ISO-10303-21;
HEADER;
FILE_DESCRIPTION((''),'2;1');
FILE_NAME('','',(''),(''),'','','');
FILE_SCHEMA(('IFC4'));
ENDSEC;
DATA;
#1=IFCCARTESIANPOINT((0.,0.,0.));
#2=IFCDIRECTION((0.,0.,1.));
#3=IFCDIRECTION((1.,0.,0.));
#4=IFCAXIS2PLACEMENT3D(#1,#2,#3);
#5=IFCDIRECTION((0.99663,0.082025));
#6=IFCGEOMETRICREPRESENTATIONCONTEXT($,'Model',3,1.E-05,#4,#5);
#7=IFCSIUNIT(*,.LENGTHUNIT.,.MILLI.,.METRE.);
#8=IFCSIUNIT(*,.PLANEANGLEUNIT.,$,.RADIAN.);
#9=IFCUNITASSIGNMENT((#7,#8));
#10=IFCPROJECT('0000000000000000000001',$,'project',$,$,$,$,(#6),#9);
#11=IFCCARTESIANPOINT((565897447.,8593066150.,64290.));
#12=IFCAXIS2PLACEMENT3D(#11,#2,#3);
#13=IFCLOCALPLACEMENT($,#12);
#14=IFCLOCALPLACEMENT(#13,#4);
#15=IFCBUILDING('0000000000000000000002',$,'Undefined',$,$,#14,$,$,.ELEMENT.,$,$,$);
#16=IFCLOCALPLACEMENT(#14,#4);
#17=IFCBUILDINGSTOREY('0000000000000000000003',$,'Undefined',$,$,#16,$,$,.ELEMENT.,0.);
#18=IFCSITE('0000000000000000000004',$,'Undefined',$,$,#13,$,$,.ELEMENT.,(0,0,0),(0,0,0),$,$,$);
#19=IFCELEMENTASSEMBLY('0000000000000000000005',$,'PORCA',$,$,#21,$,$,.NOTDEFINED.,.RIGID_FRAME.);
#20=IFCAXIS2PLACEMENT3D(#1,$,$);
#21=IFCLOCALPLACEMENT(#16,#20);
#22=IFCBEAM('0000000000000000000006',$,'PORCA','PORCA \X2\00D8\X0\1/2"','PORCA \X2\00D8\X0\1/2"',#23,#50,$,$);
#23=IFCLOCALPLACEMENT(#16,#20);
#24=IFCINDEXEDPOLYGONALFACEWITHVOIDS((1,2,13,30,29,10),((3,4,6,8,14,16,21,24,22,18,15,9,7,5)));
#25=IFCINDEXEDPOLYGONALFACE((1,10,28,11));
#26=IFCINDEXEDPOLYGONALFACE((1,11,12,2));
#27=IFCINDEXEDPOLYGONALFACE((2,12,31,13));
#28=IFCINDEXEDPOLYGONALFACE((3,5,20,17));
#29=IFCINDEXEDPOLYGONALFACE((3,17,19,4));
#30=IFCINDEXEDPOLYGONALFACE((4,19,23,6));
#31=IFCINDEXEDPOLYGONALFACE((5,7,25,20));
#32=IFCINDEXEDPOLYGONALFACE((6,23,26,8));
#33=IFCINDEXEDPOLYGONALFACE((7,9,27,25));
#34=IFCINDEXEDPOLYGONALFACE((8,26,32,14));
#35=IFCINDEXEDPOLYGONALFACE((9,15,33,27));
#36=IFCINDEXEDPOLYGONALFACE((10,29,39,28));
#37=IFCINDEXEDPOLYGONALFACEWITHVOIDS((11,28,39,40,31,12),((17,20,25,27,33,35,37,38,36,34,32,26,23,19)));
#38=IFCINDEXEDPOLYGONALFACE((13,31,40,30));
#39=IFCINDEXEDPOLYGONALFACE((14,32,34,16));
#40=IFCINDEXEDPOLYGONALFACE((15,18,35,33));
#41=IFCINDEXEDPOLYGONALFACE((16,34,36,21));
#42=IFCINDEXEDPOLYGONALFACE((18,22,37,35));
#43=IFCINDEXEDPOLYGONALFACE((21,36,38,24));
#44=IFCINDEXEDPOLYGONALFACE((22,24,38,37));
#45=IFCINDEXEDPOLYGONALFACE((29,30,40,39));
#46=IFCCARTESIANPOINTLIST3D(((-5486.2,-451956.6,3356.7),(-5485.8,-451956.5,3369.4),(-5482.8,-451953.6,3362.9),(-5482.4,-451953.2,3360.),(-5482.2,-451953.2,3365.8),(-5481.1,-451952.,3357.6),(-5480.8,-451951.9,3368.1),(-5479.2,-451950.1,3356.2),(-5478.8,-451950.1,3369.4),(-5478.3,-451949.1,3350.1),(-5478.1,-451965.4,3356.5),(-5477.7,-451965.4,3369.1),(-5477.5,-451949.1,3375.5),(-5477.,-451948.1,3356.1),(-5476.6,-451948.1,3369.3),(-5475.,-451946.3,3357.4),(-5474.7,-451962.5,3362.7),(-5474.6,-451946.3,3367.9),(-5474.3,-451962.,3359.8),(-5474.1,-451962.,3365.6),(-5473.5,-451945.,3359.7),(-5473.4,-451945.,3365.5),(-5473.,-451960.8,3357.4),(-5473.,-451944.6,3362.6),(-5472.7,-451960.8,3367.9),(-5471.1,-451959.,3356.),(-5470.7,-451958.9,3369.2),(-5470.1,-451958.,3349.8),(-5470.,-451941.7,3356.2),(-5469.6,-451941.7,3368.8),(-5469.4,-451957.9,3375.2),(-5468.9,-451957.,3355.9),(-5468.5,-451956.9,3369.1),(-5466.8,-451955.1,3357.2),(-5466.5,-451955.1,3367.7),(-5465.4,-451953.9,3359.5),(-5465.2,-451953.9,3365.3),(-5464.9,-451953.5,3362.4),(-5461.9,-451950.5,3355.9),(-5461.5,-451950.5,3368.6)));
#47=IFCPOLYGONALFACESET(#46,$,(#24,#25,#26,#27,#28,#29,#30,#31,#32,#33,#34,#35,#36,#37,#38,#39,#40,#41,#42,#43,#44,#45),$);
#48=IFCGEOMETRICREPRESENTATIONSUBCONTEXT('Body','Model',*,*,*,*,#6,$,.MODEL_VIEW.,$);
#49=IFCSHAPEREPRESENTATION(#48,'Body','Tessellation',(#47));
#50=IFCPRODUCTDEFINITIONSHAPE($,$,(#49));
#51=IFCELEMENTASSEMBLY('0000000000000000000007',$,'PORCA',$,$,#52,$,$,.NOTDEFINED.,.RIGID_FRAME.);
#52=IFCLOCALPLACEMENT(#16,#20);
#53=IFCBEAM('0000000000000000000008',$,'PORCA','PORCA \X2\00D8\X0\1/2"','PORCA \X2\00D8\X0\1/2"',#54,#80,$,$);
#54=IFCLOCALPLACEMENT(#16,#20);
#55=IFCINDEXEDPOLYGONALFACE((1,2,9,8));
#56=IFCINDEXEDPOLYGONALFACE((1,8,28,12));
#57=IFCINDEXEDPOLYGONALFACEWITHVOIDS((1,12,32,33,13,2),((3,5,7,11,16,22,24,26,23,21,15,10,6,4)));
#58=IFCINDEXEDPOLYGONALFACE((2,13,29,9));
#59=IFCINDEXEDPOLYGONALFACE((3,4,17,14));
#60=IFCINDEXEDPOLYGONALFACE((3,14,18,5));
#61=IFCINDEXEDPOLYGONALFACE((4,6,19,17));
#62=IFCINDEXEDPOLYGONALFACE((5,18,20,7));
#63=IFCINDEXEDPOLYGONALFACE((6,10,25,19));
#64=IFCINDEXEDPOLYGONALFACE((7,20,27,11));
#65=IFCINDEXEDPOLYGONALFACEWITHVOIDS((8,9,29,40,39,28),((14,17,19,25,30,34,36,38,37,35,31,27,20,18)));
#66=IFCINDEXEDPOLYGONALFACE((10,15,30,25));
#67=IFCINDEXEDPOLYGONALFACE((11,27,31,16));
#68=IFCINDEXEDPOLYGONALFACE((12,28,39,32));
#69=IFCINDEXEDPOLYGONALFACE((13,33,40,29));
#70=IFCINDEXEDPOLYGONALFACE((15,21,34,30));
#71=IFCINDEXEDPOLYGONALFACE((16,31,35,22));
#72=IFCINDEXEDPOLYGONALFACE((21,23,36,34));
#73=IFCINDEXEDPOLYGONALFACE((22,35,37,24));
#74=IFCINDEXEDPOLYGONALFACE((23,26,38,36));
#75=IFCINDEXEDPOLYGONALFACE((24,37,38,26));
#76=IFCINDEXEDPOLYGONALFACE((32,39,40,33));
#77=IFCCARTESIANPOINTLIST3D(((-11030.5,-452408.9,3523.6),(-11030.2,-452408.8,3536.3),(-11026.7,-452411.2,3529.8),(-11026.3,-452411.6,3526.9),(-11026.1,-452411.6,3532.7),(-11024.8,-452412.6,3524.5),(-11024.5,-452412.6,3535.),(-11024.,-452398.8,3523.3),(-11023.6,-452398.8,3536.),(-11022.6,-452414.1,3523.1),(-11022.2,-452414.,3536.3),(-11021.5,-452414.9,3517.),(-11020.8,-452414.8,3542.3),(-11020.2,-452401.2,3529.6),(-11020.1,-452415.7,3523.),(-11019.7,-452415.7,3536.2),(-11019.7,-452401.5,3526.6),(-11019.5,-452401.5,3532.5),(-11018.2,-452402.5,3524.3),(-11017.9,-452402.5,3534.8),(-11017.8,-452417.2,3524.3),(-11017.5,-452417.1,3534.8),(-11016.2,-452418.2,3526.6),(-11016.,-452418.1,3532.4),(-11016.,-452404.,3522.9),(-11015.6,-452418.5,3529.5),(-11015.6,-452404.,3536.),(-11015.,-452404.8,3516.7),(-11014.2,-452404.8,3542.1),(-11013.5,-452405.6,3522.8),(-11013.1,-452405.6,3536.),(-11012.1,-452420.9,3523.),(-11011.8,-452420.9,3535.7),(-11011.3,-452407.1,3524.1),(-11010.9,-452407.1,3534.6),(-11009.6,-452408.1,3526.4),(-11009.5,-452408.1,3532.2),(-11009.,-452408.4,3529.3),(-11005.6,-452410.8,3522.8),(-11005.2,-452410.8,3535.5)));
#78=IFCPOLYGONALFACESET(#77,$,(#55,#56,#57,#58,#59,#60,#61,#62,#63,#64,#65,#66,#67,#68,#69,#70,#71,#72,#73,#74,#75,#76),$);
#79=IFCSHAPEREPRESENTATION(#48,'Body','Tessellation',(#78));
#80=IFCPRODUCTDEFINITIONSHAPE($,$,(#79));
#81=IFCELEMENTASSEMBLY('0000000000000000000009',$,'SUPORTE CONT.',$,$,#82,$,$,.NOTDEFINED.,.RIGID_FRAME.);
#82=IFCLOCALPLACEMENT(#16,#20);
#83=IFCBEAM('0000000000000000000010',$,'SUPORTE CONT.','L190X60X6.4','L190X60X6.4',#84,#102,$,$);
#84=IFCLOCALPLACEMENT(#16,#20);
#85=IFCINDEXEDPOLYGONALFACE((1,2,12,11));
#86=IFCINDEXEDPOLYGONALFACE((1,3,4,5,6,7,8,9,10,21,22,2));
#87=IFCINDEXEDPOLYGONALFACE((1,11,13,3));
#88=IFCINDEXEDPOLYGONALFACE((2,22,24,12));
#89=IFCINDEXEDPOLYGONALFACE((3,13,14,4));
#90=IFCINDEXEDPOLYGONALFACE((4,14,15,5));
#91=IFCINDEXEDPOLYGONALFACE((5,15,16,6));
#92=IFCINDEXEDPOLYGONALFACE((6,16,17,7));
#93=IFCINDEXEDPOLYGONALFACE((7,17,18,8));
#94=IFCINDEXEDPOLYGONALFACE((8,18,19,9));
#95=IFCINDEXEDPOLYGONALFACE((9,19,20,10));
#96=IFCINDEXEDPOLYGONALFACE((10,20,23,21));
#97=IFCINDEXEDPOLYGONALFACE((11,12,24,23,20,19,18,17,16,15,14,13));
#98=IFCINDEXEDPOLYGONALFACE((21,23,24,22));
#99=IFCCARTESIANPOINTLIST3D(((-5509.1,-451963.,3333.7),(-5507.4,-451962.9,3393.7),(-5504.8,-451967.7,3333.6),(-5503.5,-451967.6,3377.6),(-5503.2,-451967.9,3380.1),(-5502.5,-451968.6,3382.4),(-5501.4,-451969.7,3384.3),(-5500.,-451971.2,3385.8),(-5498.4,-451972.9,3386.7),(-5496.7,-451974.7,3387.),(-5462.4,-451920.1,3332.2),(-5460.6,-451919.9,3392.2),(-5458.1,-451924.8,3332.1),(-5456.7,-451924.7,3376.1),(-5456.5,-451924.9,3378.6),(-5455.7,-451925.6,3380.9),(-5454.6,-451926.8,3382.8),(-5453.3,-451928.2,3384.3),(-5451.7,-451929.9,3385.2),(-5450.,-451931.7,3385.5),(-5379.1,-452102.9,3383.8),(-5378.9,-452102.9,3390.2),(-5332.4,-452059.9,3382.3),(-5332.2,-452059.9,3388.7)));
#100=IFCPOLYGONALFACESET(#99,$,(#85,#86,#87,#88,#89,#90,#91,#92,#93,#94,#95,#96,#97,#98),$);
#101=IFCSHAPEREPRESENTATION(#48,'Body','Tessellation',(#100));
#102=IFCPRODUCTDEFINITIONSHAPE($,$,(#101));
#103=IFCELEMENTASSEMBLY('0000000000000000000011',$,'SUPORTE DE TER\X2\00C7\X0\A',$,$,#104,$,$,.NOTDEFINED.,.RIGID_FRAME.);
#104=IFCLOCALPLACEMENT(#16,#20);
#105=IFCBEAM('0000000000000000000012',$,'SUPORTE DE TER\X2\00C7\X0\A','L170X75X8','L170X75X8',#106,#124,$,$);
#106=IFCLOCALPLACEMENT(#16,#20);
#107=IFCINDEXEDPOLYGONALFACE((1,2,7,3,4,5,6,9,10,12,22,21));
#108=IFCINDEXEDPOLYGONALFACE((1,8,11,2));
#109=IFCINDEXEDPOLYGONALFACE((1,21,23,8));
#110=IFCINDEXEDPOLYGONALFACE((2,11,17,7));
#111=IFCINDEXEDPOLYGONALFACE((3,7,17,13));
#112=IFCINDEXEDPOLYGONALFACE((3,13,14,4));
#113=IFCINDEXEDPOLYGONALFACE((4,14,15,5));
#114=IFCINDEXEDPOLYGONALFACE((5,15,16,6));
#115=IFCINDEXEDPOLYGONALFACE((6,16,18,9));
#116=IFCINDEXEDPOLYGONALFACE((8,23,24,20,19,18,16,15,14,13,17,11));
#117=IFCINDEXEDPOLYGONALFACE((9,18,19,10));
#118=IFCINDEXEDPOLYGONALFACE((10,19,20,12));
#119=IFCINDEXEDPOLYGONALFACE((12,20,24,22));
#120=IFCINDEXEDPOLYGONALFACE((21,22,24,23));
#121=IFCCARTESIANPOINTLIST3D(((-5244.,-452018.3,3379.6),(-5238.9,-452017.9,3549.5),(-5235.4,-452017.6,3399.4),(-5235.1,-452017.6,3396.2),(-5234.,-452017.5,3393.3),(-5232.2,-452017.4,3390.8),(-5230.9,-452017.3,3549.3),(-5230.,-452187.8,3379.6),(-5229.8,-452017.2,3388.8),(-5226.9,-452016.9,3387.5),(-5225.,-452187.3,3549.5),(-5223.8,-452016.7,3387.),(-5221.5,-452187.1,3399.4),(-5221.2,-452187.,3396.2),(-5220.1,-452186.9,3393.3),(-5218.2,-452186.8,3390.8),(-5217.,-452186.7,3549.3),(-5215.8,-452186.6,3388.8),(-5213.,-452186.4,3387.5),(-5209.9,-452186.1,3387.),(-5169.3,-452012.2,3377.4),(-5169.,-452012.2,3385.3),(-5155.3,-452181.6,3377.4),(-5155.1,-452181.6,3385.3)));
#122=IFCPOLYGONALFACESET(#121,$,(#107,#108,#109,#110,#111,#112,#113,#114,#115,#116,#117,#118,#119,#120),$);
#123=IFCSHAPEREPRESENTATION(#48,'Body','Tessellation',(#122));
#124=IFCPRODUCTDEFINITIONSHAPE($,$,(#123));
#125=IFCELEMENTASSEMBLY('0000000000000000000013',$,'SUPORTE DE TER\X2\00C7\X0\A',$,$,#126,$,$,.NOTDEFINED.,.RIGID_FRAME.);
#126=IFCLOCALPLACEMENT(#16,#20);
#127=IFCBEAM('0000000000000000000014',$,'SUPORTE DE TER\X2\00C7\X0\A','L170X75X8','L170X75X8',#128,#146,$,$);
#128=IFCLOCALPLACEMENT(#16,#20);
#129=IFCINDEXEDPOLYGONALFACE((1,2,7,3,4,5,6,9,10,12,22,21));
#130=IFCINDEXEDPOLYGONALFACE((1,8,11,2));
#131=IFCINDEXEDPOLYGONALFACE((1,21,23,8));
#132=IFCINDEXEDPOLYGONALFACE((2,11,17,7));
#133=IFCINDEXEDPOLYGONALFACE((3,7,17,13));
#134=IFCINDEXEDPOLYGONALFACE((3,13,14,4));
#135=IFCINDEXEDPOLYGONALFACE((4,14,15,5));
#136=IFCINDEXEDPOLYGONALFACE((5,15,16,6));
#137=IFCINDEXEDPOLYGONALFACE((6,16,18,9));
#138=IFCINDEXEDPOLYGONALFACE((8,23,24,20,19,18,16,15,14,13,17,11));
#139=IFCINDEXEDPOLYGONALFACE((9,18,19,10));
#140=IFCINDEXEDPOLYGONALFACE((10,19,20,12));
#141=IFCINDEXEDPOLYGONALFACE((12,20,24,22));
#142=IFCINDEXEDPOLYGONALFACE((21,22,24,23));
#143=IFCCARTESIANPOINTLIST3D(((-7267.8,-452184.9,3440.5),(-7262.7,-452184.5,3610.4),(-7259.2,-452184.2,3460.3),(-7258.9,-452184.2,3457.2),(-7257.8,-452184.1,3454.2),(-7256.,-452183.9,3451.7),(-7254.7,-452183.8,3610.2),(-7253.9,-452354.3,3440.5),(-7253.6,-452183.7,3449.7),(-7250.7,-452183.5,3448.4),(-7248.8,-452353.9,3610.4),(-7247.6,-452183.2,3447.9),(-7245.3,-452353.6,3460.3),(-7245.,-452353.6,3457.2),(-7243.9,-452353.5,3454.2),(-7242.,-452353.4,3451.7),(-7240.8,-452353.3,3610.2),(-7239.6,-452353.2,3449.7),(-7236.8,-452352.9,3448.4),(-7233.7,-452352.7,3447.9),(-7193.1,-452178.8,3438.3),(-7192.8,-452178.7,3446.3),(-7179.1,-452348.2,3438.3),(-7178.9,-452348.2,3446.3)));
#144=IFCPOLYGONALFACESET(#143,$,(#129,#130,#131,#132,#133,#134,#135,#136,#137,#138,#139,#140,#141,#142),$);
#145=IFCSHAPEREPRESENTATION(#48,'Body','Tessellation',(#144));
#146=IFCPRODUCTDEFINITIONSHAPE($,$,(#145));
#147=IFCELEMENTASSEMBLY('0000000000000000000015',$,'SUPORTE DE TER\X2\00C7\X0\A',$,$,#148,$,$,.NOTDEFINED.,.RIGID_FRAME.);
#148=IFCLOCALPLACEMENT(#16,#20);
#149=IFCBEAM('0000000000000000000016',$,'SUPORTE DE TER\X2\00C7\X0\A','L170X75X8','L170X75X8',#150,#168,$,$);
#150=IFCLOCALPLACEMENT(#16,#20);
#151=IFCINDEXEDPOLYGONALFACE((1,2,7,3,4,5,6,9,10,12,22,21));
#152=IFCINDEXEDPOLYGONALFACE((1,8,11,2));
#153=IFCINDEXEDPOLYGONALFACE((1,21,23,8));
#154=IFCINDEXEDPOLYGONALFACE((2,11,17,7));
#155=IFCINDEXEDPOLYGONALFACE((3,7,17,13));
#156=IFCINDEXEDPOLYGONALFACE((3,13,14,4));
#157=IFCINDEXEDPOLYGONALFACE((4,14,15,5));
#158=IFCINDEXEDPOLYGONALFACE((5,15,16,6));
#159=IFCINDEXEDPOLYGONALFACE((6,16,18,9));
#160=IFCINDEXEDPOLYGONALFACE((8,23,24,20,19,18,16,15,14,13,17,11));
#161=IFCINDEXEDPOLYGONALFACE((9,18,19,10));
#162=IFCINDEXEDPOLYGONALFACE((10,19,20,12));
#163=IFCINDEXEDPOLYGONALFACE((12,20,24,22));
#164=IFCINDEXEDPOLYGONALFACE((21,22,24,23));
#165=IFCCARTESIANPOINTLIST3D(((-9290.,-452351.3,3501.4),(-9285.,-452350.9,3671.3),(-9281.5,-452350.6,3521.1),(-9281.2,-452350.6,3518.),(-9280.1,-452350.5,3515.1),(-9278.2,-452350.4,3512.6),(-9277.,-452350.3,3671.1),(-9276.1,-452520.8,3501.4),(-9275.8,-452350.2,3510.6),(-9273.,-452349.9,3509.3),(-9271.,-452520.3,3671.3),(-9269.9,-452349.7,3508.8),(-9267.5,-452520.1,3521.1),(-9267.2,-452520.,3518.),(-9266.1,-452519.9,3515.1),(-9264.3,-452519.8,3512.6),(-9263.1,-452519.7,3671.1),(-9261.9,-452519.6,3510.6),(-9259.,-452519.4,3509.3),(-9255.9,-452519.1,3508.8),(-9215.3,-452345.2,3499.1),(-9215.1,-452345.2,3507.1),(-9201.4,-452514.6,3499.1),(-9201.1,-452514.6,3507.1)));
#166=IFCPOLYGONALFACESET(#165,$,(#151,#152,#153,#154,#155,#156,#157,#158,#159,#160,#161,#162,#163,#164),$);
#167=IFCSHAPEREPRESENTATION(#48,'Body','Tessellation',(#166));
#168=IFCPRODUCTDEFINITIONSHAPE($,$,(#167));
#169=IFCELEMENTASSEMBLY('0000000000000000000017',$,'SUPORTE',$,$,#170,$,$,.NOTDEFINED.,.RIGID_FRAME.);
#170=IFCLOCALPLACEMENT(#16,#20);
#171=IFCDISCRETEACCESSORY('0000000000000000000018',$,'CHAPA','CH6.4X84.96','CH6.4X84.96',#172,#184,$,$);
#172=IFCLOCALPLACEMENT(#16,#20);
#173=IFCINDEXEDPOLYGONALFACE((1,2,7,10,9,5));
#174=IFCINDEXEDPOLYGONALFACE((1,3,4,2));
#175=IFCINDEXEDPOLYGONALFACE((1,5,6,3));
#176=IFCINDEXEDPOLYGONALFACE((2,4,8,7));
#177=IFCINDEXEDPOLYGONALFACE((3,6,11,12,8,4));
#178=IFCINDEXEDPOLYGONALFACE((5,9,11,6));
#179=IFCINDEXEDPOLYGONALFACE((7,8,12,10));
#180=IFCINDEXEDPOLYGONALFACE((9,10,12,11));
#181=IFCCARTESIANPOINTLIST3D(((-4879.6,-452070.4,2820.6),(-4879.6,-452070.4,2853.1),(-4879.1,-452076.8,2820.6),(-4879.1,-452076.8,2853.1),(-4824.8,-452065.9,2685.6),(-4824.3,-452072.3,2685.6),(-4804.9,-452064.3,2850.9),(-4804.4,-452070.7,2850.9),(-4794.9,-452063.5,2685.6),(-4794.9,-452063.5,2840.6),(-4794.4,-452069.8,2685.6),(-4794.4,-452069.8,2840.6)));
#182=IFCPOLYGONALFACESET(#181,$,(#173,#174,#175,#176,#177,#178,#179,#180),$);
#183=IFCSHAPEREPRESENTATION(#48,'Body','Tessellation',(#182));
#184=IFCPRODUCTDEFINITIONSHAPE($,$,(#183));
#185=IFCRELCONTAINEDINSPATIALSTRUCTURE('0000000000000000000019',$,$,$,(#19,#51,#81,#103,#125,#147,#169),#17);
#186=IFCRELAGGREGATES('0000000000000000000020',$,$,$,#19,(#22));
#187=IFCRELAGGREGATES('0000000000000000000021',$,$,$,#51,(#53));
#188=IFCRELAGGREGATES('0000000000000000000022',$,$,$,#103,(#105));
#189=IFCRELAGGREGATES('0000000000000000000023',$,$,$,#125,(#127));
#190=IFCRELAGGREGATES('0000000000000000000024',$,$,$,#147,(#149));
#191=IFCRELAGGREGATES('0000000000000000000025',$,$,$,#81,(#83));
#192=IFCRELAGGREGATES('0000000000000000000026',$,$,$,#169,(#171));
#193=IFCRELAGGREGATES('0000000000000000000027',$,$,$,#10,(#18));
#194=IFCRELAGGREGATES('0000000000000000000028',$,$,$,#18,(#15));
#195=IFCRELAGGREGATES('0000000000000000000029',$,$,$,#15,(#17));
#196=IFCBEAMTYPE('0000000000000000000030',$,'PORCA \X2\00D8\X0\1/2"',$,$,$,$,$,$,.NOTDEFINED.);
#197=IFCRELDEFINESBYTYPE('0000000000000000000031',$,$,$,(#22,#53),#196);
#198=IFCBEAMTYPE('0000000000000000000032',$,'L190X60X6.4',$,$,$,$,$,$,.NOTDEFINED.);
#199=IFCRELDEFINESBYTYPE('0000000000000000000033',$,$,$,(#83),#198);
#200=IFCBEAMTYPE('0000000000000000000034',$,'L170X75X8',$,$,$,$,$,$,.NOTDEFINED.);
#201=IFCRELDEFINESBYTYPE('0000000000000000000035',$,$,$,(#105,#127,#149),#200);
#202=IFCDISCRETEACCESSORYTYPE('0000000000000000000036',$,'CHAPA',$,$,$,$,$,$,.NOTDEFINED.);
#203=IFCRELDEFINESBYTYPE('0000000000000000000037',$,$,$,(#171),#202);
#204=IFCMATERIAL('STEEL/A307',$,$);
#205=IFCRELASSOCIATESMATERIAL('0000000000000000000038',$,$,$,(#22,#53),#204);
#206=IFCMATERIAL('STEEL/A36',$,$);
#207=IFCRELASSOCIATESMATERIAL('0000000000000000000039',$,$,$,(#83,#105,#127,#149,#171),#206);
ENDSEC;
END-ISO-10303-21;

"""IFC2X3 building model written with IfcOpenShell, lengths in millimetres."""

from ifc_helpers import new_model, si_unit, direction, frame, origin_with_axes, origin_2d_with_axis, place, context, subcontext, project, spatial, polyline, l_section, outline, extrude, material, type_object, element, aggregate, save


model = new_model("IFC2X3")

# Units and contexts
model_context = context("Model", 3, precision=1e-05, world=origin_with_axes(), true_north=direction((0.99663, 0.082025)))
body_context = subcontext(model_context, "Body", "Model", "MODEL_VIEW")
ifc_project = project(units=[si_unit("LENGTHUNIT", "METRE", prefix="MILLI"), si_unit("PLANEANGLEUNIT", "RADIAN")], contexts=[model_context])

# Site, building, storey
site_placement = place(None, frame((565897447.0, 8593066150.0, 64290.0), z_axis=(0.0, 0.0, 1.0), x_axis=(1.0, 0.0, 0.0)))
site = spatial("IfcSite", under=ifc_project, at=site_placement, Name="Undefined", CompositionType="ELEMENT", RefLatitude=(0, 0, 0), RefLongitude=(0, 0, 0))
building_placement = place(site_placement, origin_with_axes())
building = spatial("IfcBuilding", under=site, at=building_placement, Name="Undefined", CompositionType="ELEMENT")
storey_placement = place(building_placement, origin_with_axes())
storey = spatial("IfcBuildingStorey", under=building, at=storey_placement, Name="Undefined", CompositionType="ELEMENT", Elevation=0.0)

# Element assemblies, beams
ifc_material_1 = material(Name="STEEL/A307")
assembly_1_placement = place(storey_placement, origin_with_axes())
assembly_1 = element("IfcElementAssembly", 1, at=assembly_1_placement, inside=storey, Name="PORCA", AssemblyPlace="NOTDEFINED", PredefinedType="RIGID_FRAME")
beam_type_1 = type_object("IfcBeamType", Name="PORCA Ø1/2\"", PredefinedType="NOTDEFINED")
beam_1_placement = place(assembly_1_placement, frame((-5469.8, -451958.0, 3362.5), z_axis=(-0.736334, -0.676203, 0.02368), x_axis=(-0.675958, 0.736711, 0.018398)))
beam_1 = element("IfcBeam", 2, at=beam_1_placement, type_object=beam_type_1, material=ifc_material_1, Name="PORCA", Description="PORCA Ø1/2\"", ObjectType="PORCA Ø1/2\"", context=body_context, shape_type="SweptSolid", body=[
    extrude(outline(polyline([(-6.3, -11.0), (-12.7, 0.0), (-6.3, 11.0), (6.3, 11.0), (12.7, 0.0), (6.3, -11.0), (-6.3, -11.0)]), holes=[polyline([(5.3, 4.2), (2.9, 6.0), (0.0, 6.7), (-2.9, 6.0), (-5.3, 4.2), (-6.6, 1.5), (-6.6, -1.5), (-5.3, -4.2), (-2.9, -6.0), (0.0, -6.7), (2.9, -6.0), (5.3, -4.2), (6.6, -1.5), (6.6, 1.5), (5.3, 4.2)])]), frame((12.0, 0.0, 0.0), z_axis=(-1.0, 0.0, 0.0), x_axis=(0.0, -1.0, 0.0)), (0.0, 0.0, 1.0), 12.0),
])
aggregate(assembly_1, [beam_1])
assembly_2_placement = place(storey_placement, origin_with_axes())
assembly_2 = element("IfcElementAssembly", 3, at=assembly_2_placement, inside=storey, Name="PORCA", AssemblyPlace="NOTDEFINED", PredefinedType="RIGID_FRAME")
beam_2_placement = place(assembly_2_placement, frame((-11021.1, -452414.9, 3529.6), z_axis=(-0.836984, 0.546715, 0.02368), x_axis=(0.546411, 0.837315, -0.018398)))
beam_2 = element("IfcBeam", 4, at=beam_2_placement, type_object=beam_type_1, material=ifc_material_1, Name="PORCA", Description="PORCA Ø1/2\"", ObjectType="PORCA Ø1/2\"", context=body_context, shape_type="SweptSolid", body=[
    extrude(outline(polyline([(-6.3, -11.0), (-12.7, 0.0), (-6.3, 11.0), (6.3, 11.0), (12.7, 0.0), (6.3, -11.0), (-6.3, -11.0)]), holes=[polyline([(5.3, 4.2), (2.9, 6.0), (0.0, 6.7), (-2.9, 6.0), (-5.3, 4.2), (-6.6, 1.5), (-6.6, -1.5), (-5.3, -4.2), (-2.9, -6.0), (0.0, -6.7), (2.9, -6.0), (5.3, -4.2), (6.6, -1.5), (6.6, 1.5), (5.3, 4.2)])]), frame((12.0, 0.0, 0.0), z_axis=(-1.0, 0.0, 0.0), x_axis=(0.0, -1.0, 0.0)), (0.0, 0.0, 1.0), 12.0),
])
aggregate(assembly_2, [beam_2])
assembly_3_placement = place(storey_placement, origin_with_axes())
assembly_3 = element("IfcElementAssembly", 5, at=assembly_3_placement, inside=storey, Name="SUPORTE CONT.", AssemblyPlace="NOTDEFINED", PredefinedType="RIGID_FRAME")
ifc_material_2 = material(Name="STEEL/A36")
beam_type_2 = type_object("IfcBeamType", Name="L190X60X6.4", PredefinedType="NOTDEFINED")
beam_3_placement = place(assembly_3_placement, frame((-5444.0, -452032.9, 3362.0), z_axis=(0.675958, -0.736711, -0.018398), x_axis=(0.736334, 0.676203, -0.02368)))
beam_3 = element("IfcBeam", 6, at=beam_3_placement, type_object=beam_type_2, material=ifc_material_2, Name="SUPORTE CONT.", Description="L190X60X6.4", ObjectType="L190X60X6.4", context=body_context, shape_type="SweptSolid", body=[
    extrude(l_section(Depth=190.0, Width=60.0, Thickness=6.4, FilletRadius=9.6, at=origin_2d_with_axis()), frame((63.5, 0.0, 0.0), z_axis=(-1.0, 0.0, 0.0), x_axis=(0.0, -1.0, 0.0)), (0.0, 0.0, 1.0), 63.5),
])
assembly_4_placement = place(storey_placement, origin_with_axes())
assembly_4 = element("IfcElementAssembly", 7, at=assembly_4_placement, inside=storey, Name="SUPORTE DE TERÇA", AssemblyPlace="NOTDEFINED", PredefinedType="RIGID_FRAME")
beam_type_3 = type_object("IfcBeamType", Name="L170X75X8", PredefinedType="NOTDEFINED")
beam_4_placement = place(assembly_4_placement, frame((-5190.2, -452184.5, 3463.4), z_axis=(0.029885, 0.00246, 0.99955), x_axis=(-0.082025, 0.99663, 0.0)))
beam_4 = element("IfcBeam", 8, at=beam_4_placement, type_object=beam_type_3, material=ifc_material_2, Name="SUPORTE DE TERÇA", Description="L170X75X8", ObjectType="L170X75X8", context=body_context, shape_type="SweptSolid", body=[
    extrude(l_section(Depth=170.0, Width=75.0, Thickness=8.0, FilletRadius=12.0, at=origin_2d_with_axis()), frame((170.0, 0.0, 0.0), z_axis=(-1.0, 0.0, 0.0), x_axis=(0.0, -1.0, 0.0)), (0.0, 0.0, 1.0), 170.0),
])
aggregate(assembly_4, [beam_4])
assembly_5_placement = place(storey_placement, origin_with_axes())
assembly_5 = element("IfcElementAssembly", 9, at=assembly_5_placement, inside=storey, Name="SUPORTE DE TERÇA", AssemblyPlace="NOTDEFINED", PredefinedType="RIGID_FRAME")
beam_5_placement = place(assembly_5_placement, frame((-7214.0, -452351.0, 3524.4), z_axis=(0.029885, 0.00246, 0.99955), x_axis=(-0.082025, 0.99663, 0.0)))
beam_5 = element("IfcBeam", 10, at=beam_5_placement, type_object=beam_type_3, material=ifc_material_2, Name="SUPORTE DE TERÇA", Description="L170X75X8", ObjectType="L170X75X8", context=body_context, shape_type="SweptSolid", body=[
    extrude(l_section(Depth=170.0, Width=75.0, Thickness=8.0, FilletRadius=12.0, at=origin_2d_with_axis()), frame((170.0, 0.0, 0.0), z_axis=(-1.0, 0.0, 0.0), x_axis=(0.0, -1.0, 0.0)), (0.0, 0.0, 1.0), 170.0),
])
aggregate(assembly_5, [beam_5])
assembly_6_placement = place(storey_placement, origin_with_axes())
assembly_6 = element("IfcElementAssembly", 11, at=assembly_6_placement, inside=storey, Name="SUPORTE DE TERÇA", AssemblyPlace="NOTDEFINED", PredefinedType="RIGID_FRAME")
beam_6_placement = place(assembly_6_placement, frame((-9236.2, -452517.5, 3585.2), z_axis=(0.029885, 0.00246, 0.99955), x_axis=(-0.082025, 0.99663, 0.0)))
beam_6 = element("IfcBeam", 12, at=beam_6_placement, type_object=beam_type_3, material=ifc_material_2, Name="SUPORTE DE TERÇA", Description="L170X75X8", ObjectType="L170X75X8", context=body_context, shape_type="SweptSolid", body=[
    extrude(l_section(Depth=170.0, Width=75.0, Thickness=8.0, FilletRadius=12.0, at=origin_2d_with_axis()), frame((170.0, 0.0, 0.0), z_axis=(-1.0, 0.0, 0.0), x_axis=(0.0, -1.0, 0.0)), (0.0, 0.0, 1.0), 170.0),
])
aggregate(assembly_6, [beam_6])

# Shared definitions
discrete_accessory_type_1 = type_object("IfcDiscreteAccessoryType", Name="CHAPA")

aggregate(assembly_3, [beam_3])

# Element assembly, discrete accessory
assembly_7_placement = place(storey_placement, origin_with_axes())
assembly_7 = element("IfcElementAssembly", 13, at=assembly_7_placement, inside=storey, Name="SUPORTE", AssemblyPlace="NOTDEFINED", PredefinedType="RIGID_FRAME")
discrete_accessory_1_placement = place(assembly_7_placement, frame((-4794.7, -452066.6, 2850.6), z_axis=(-0.082025, 0.99663, 0.0), x_axis=(0.0, 0.0, -1.0)))
discrete_accessory_1 = element("IfcDiscreteAccessory", 14, at=discrete_accessory_1_placement, type_object=discrete_accessory_type_1, material=ifc_material_2, Name="CHAPA", Description="CH6.4X84.96", ObjectType="CH6.4X84.96", context=body_context, shape_type="SweptSolid", body=[
    extrude(outline(polyline([(-0.3, 10.0), (10.0, 0.0), (165.0, 0.0), (165.0, 30.0), (30.0, 85.0), (-2.5, 85.0), (-0.3, 10.0)])), frame((0.0, 0.0, -3.2), z_axis=(0.0, 0.0, 1.0), x_axis=(1.0, 0.0, 0.0)), (0.0, 0.0, 1.0), 6.4),
])
aggregate(assembly_7, [discrete_accessory_1])

save(model, "model.ifc")
